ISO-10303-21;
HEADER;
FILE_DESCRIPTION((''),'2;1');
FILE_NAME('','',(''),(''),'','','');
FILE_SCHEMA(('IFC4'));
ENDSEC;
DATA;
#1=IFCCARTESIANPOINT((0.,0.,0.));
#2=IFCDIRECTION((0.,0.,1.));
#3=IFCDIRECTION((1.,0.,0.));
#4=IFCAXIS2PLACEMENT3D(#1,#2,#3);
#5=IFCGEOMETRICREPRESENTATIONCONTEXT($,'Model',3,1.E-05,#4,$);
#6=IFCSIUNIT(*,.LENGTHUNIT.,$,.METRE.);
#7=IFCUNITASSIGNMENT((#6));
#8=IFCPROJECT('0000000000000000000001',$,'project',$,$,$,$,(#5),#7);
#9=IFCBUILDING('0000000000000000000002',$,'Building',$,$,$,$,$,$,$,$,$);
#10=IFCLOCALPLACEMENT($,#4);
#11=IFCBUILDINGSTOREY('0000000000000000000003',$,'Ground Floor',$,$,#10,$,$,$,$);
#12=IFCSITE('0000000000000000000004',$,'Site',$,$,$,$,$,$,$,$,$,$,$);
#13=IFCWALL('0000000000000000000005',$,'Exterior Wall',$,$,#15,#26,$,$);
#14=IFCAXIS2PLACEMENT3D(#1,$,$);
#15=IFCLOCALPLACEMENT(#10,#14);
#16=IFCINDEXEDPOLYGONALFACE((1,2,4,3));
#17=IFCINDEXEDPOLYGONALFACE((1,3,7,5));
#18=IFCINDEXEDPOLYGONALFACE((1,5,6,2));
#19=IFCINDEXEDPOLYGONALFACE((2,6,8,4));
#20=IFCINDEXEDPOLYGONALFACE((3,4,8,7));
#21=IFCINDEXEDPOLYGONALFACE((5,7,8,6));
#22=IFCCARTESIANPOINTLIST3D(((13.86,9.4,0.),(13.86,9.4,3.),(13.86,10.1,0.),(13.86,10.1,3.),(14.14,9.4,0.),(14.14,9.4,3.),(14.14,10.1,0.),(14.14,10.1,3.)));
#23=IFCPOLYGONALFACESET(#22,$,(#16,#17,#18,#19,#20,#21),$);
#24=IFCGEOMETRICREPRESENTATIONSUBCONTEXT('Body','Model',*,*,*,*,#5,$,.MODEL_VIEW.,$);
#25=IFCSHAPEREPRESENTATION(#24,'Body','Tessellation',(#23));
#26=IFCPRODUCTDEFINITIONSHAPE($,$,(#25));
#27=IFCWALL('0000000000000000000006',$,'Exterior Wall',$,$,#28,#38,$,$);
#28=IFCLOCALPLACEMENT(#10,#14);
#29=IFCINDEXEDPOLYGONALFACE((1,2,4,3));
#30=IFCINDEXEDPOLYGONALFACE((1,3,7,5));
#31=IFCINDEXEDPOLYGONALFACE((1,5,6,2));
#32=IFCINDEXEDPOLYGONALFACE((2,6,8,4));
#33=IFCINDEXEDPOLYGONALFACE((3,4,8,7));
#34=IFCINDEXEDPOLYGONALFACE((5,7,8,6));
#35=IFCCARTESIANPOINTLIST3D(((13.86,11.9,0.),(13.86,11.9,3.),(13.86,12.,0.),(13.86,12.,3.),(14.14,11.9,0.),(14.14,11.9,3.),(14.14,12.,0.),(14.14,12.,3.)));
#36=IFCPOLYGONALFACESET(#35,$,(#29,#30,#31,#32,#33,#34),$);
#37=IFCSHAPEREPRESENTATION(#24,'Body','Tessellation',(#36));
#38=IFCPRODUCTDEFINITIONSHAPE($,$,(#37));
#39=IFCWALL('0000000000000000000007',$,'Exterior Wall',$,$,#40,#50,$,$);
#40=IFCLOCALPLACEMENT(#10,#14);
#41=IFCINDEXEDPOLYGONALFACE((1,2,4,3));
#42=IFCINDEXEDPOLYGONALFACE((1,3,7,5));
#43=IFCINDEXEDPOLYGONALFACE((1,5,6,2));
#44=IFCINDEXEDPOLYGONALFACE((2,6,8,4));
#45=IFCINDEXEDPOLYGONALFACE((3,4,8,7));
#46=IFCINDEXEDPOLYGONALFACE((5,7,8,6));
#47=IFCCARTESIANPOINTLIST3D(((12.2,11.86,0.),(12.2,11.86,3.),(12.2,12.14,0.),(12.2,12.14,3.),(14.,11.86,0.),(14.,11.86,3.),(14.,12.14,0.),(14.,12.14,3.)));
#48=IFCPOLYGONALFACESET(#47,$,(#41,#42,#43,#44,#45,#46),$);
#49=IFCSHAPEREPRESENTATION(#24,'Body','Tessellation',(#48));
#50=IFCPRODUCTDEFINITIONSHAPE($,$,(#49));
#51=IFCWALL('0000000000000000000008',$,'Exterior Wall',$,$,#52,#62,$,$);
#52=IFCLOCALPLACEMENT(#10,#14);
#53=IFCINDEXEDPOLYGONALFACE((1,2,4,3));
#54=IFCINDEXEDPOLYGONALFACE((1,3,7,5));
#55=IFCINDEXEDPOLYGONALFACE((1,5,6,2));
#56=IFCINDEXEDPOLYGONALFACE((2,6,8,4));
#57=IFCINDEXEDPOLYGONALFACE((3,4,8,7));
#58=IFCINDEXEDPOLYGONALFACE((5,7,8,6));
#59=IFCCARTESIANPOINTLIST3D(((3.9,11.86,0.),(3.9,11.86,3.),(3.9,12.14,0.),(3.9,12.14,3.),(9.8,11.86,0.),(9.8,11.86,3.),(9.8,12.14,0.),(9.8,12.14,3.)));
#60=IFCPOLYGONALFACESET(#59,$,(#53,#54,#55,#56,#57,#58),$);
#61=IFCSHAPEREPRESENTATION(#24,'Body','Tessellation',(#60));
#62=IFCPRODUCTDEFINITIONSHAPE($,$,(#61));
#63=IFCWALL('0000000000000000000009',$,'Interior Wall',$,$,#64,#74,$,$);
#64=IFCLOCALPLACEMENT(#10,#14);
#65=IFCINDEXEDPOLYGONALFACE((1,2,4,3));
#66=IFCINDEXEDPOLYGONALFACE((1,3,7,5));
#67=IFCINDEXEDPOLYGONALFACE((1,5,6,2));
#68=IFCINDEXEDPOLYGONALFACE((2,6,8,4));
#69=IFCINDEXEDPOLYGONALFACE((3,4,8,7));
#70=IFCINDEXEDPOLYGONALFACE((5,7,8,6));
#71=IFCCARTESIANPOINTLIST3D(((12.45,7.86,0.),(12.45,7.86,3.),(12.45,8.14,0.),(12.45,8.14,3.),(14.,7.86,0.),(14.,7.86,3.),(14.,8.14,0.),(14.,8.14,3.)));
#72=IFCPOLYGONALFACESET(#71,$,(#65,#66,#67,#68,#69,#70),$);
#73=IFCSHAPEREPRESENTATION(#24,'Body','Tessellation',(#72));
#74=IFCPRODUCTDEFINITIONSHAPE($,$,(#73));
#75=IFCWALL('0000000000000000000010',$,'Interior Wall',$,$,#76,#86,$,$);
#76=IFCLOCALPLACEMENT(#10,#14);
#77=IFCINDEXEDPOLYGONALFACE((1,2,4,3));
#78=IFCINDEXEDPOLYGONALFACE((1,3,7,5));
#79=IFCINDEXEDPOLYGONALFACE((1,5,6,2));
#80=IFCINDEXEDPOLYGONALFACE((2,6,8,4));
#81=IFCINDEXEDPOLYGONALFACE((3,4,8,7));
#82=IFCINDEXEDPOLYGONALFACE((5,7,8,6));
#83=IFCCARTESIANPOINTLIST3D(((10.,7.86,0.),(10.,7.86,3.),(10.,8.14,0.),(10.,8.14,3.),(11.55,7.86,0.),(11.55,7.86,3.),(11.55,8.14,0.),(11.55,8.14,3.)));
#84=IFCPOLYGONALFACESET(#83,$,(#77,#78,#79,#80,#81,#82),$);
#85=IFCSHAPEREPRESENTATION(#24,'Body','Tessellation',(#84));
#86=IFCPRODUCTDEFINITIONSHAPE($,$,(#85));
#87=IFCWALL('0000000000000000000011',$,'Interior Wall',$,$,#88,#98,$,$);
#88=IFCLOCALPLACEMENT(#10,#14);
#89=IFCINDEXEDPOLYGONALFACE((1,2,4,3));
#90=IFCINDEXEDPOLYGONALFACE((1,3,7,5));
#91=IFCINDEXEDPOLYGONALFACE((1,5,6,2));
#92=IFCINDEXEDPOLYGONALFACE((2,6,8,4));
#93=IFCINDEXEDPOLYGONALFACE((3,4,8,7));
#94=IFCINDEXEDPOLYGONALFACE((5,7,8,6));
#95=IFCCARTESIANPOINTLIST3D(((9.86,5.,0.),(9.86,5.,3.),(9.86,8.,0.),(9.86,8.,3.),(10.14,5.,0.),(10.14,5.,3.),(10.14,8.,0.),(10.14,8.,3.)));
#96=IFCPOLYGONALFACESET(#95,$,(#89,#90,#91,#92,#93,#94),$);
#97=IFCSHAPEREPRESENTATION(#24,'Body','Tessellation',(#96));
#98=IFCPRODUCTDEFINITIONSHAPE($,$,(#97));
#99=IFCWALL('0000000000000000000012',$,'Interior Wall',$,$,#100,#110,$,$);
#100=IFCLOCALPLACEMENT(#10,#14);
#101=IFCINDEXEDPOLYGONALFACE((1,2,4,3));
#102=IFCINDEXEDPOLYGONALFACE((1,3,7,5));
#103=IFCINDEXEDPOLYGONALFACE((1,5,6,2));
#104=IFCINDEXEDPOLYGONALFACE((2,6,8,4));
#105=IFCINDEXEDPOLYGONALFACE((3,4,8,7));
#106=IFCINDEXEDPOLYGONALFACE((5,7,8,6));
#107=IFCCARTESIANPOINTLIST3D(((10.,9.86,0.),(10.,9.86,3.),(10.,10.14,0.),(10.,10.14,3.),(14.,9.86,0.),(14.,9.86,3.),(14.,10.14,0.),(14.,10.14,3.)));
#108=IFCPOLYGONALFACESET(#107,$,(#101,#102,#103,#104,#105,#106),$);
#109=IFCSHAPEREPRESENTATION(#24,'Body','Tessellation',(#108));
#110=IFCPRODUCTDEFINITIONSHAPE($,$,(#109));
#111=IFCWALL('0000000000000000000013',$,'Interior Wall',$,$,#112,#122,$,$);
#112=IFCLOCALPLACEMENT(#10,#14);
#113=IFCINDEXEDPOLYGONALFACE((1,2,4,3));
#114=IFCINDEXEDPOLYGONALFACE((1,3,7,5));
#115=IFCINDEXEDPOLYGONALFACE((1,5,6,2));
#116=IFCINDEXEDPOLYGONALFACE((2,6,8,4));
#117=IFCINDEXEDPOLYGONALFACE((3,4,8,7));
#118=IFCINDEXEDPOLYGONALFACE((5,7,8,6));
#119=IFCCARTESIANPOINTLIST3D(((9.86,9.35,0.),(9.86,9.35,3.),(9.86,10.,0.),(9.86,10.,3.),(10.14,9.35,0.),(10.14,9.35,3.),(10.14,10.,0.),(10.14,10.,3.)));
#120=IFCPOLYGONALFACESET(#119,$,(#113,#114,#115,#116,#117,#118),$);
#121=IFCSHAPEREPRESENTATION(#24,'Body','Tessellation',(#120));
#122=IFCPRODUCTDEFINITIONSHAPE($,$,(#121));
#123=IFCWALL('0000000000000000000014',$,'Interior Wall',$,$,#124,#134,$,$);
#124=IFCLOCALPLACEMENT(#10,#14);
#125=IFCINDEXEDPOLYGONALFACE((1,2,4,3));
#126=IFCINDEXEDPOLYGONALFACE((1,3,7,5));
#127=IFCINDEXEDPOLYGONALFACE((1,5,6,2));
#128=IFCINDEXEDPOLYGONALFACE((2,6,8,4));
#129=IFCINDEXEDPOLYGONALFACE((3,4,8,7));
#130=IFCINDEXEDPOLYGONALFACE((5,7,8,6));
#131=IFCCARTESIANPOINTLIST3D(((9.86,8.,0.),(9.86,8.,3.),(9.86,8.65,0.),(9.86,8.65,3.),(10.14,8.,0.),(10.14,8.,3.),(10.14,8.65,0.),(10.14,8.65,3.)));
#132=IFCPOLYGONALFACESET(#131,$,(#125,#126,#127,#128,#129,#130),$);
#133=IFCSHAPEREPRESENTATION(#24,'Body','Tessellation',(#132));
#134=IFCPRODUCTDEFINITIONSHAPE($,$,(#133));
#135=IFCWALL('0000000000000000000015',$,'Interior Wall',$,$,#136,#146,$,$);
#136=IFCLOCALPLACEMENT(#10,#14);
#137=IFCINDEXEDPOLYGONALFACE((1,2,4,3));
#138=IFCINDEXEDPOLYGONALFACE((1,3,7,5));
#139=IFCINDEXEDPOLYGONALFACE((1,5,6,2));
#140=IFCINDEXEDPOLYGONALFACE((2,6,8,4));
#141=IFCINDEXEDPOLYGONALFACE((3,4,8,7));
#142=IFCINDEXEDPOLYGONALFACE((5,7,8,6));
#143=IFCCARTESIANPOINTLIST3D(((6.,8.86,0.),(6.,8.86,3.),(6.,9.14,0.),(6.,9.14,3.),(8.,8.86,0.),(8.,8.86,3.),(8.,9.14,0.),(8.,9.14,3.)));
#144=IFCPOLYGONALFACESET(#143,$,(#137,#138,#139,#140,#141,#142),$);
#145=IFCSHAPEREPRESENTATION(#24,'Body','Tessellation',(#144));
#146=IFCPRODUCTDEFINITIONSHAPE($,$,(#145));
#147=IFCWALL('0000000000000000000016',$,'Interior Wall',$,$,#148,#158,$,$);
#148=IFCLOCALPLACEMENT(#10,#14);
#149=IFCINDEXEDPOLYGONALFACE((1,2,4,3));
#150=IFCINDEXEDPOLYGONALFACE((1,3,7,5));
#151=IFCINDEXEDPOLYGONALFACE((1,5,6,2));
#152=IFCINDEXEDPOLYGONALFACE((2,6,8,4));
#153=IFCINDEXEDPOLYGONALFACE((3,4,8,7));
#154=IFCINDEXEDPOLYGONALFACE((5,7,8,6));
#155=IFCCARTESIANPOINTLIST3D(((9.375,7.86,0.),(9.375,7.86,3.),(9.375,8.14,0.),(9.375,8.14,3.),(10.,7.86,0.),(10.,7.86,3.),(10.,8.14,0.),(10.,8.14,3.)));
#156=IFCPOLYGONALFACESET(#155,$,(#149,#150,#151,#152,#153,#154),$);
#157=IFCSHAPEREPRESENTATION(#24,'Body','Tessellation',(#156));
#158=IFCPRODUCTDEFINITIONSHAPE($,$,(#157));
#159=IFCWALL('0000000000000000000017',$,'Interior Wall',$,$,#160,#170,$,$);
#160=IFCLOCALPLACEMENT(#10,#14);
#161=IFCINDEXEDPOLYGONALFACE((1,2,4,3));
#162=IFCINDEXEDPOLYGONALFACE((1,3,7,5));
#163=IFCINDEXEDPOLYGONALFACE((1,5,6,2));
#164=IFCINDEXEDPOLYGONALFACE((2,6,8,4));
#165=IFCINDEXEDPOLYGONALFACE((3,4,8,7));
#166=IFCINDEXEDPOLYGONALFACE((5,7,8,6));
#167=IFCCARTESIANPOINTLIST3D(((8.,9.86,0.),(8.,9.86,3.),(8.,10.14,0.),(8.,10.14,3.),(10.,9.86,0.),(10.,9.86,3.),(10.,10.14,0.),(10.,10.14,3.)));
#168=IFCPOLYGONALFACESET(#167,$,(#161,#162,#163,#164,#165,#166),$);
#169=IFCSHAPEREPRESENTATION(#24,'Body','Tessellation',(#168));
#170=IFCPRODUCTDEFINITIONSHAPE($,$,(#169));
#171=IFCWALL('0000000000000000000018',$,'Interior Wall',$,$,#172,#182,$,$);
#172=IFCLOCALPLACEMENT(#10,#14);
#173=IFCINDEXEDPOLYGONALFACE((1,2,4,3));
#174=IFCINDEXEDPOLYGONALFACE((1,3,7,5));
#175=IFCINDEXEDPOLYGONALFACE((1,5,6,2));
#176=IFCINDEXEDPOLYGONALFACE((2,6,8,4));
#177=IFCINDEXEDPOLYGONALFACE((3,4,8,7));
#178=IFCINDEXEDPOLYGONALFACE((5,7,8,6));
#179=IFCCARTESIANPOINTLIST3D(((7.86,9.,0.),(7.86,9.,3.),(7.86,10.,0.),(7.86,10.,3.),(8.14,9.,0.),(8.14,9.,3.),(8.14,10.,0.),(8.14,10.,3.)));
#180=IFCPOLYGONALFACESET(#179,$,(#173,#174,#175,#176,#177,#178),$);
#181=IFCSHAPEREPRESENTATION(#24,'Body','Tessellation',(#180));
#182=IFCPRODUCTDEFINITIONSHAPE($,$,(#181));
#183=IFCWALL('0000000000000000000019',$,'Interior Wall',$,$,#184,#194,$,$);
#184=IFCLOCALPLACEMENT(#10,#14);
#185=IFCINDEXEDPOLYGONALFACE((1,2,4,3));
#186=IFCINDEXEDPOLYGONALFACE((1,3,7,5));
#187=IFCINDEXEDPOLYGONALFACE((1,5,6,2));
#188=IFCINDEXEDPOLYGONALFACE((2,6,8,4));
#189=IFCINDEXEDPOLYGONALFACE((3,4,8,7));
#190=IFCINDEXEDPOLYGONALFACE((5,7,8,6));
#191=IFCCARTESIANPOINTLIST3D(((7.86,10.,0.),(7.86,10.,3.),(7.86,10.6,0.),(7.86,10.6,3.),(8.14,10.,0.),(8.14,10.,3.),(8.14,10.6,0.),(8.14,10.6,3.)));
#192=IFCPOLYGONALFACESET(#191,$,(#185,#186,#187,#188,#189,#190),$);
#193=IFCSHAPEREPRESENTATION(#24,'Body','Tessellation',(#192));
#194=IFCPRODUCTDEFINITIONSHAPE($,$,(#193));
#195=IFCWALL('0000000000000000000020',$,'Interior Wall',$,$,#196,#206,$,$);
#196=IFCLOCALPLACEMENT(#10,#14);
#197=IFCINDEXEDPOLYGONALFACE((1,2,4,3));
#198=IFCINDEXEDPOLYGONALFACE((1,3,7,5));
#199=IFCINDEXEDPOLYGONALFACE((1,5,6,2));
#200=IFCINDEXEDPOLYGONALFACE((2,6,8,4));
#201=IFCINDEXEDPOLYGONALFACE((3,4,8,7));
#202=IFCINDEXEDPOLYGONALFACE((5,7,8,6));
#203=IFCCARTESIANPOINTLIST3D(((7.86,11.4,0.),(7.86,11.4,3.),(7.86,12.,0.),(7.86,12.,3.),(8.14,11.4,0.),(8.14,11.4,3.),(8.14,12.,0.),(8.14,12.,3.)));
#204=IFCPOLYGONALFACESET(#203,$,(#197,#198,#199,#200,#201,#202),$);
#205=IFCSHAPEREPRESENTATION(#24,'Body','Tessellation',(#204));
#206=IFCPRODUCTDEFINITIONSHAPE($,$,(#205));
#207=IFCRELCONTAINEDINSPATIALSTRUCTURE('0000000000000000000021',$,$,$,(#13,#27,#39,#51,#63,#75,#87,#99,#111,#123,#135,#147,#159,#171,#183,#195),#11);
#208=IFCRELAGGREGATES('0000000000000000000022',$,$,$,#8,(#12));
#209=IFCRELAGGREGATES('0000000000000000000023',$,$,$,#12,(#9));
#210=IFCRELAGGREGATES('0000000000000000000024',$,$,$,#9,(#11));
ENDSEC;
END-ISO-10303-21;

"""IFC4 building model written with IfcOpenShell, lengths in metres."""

from ifc_helpers import new_model, si_unit, frame, origin_with_axes, place, context, subcontext, project, spatial, indexed_curve, outline, extrude, element, save


model = new_model("IFC4")

# Units and contexts
model_context = context("Model", 3, precision=1e-05, world=origin_with_axes())
body_context = subcontext(model_context, "Body", "Model", "MODEL_VIEW")
ifc_project = project(units=[si_unit("LENGTHUNIT", "METRE")], contexts=[model_context])

# Site, building, storey
site = spatial("IfcSite", under=ifc_project, Name="Site")
building = spatial("IfcBuilding", under=site, Name="Building")
storey_placement = place(None, origin_with_axes())
storey = spatial("IfcBuildingStorey", under=building, at=storey_placement, Name="Ground Floor")

# Walls
wall_1_placement = place(storey_placement, frame((14.0, 9.4, 0.0), z_axis=(0.0, 0.0, 1.0), x_axis=(0.0, 1.0, 0.0)))
element("IfcWall", 1, at=wall_1_placement, inside=storey, Name="Exterior Wall", context=body_context, shape_type="SweptSolid", body=[
    extrude(outline(indexed_curve([(0.0, 0.0), (0.0, 0.28), (0.7, 0.28), (0.7, 0.0), (0.0, 0.0)], self_intersect=False)), frame((0.0, -0.14, 0.0), z_axis=(0.0, 0.0, 1.0), x_axis=(1.0, 0.0, 0.0)), (0.0, 0.0, 1.0), 3.0),
])
wall_2_placement = place(storey_placement, frame((14.0, 11.9, 0.0), z_axis=(0.0, 0.0, 1.0), x_axis=(0.0, 1.0, 0.0)))
element("IfcWall", 2, at=wall_2_placement, inside=storey, Name="Exterior Wall", context=body_context, shape_type="SweptSolid", body=[
    extrude(outline(indexed_curve([(0.0, 0.0), (0.0, 0.28), (0.1, 0.28), (0.1, 0.0), (0.0, 0.0)], self_intersect=False)), frame((0.0, -0.14, 0.0), z_axis=(0.0, 0.0, 1.0), x_axis=(1.0, 0.0, 0.0)), (0.0, 0.0, 1.0), 3.0),
])
wall_3_placement = place(storey_placement, frame((14.0, 12.0, 0.0), z_axis=(0.0, 0.0, 1.0), x_axis=(-1.0, 0.0, 0.0)))
element("IfcWall", 3, at=wall_3_placement, inside=storey, Name="Exterior Wall", context=body_context, shape_type="SweptSolid", body=[
    extrude(outline(indexed_curve([(0.0, 0.0), (0.0, 0.28), (1.8, 0.28), (1.8, 0.0), (0.0, 0.0)], self_intersect=False)), frame((0.0, -0.14, 0.0), z_axis=(0.0, 0.0, 1.0), x_axis=(1.0, 0.0, 0.0)), (0.0, 0.0, 1.0), 3.0),
])
wall_4_placement = place(storey_placement, frame((9.8, 12.0, 0.0), z_axis=(0.0, 0.0, 1.0), x_axis=(-1.0, 0.0, 0.0)))
element("IfcWall", 4, at=wall_4_placement, inside=storey, Name="Exterior Wall", context=body_context, shape_type="SweptSolid", body=[
    extrude(outline(indexed_curve([(0.0, 0.0), (0.0, 0.28), (5.9, 0.28), (5.9, 0.0), (0.0, 0.0)], self_intersect=False)), frame((0.0, -0.14, 0.0), z_axis=(0.0, 0.0, 1.0), x_axis=(1.0, 0.0, 0.0)), (0.0, 0.0, 1.0), 3.0),
])
for number, where, z_axis, x_axis, name in (
    (5, (14.0, 8.0, 0.0), (0.0, 0.0, 1.0), (-1.0, 0.0, 0.0), "Interior Wall"),
    (6, (11.55, 8.0, 0.0), (0.0, 0.0, 1.0), (-1.0, 0.0, 0.0), "Interior Wall"),
):
    element("IfcWall", number, at=place(storey_placement, frame(where, z_axis=z_axis, x_axis=x_axis)), inside=storey, Name=name, context=body_context, shape_type="SweptSolid", body=[
        extrude(outline(indexed_curve([(0.0, 0.0), (0.0, 0.28), (1.55, 0.28), (1.55, 0.0), (0.0, 0.0)], self_intersect=False)), frame((0.0, -0.14, 0.0), z_axis=(0.0, 0.0, 1.0), x_axis=(1.0, 0.0, 0.0)), (0.0, 0.0, 1.0), 3.0),
    ])
wall_5_placement = place(storey_placement, frame((10.0, 8.0, 0.0), z_axis=(0.0, 0.0, 1.0), x_axis=(0.0, -1.0, 0.0)))
element("IfcWall", 7, at=wall_5_placement, inside=storey, Name="Interior Wall", context=body_context, shape_type="SweptSolid", body=[
    extrude(outline(indexed_curve([(0.0, 0.0), (0.0, 0.28), (3.0, 0.28), (3.0, 0.0), (0.0, 0.0)], self_intersect=False)), frame((0.0, -0.14, 0.0), z_axis=(0.0, 0.0, 1.0), x_axis=(1.0, 0.0, 0.0)), (0.0, 0.0, 1.0), 3.0),
])
wall_6_placement = place(storey_placement, frame((14.0, 10.0, 0.0), z_axis=(0.0, 0.0, 1.0), x_axis=(-1.0, 0.0, 0.0)))
element("IfcWall", 8, at=wall_6_placement, inside=storey, Name="Interior Wall", context=body_context, shape_type="SweptSolid", body=[
    extrude(outline(indexed_curve([(0.0, 0.0), (0.0, 0.28), (4.0, 0.28), (4.0, 0.0), (0.0, 0.0)], self_intersect=False)), frame((0.0, -0.14, 0.0), z_axis=(0.0, 0.0, 1.0), x_axis=(1.0, 0.0, 0.0)), (0.0, 0.0, 1.0), 3.0),
])
for number, where, z_axis, x_axis, name in (
    (9, (10.0, 10.0, 0.0), (0.0, 0.0, 1.0), (0.0, -1.0, 0.0), "Interior Wall"),
    (10, (10.0, 8.65, 0.0), (0.0, 0.0, 1.0), (0.0, -1.0, 0.0), "Interior Wall"),
):
    element("IfcWall", number, at=place(storey_placement, frame(where, z_axis=z_axis, x_axis=x_axis)), inside=storey, Name=name, context=body_context, shape_type="SweptSolid", body=[
        extrude(outline(indexed_curve([(0.0, 0.0), (0.0, 0.28), (0.65, 0.28), (0.65, 0.0), (0.0, 0.0)], self_intersect=False)), frame((0.0, -0.14, 0.0), z_axis=(0.0, 0.0, 1.0), x_axis=(1.0, 0.0, 0.0)), (0.0, 0.0, 1.0), 3.0),
    ])
wall_7_placement = place(storey_placement, frame((8.0, 9.0, 0.0), z_axis=(0.0, 0.0, 1.0), x_axis=(-1.0, 0.0, 0.0)))
element("IfcWall", 11, at=wall_7_placement, inside=storey, Name="Interior Wall", context=body_context, shape_type="SweptSolid", body=[
    extrude(outline(indexed_curve([(0.0, 0.0), (0.0, 0.28), (2.0, 0.28), (2.0, 0.0), (0.0, 0.0)], self_intersect=False)), frame((0.0, -0.14, 0.0), z_axis=(0.0, 0.0, 1.0), x_axis=(1.0, 0.0, 0.0)), (0.0, 0.0, 1.0), 3.0),
])
wall_8_placement = place(storey_placement, frame((10.0, 8.0, 0.0), z_axis=(0.0, 0.0, 1.0), x_axis=(-1.0, 0.0, 0.0)))
element("IfcWall", 12, at=wall_8_placement, inside=storey, Name="Interior Wall", context=body_context, shape_type="SweptSolid", body=[
    extrude(outline(indexed_curve([(0.0, 0.0), (0.0, 0.28), (0.625, 0.28), (0.625, 0.0), (0.0, 0.0)], self_intersect=False)), frame((0.0, -0.14, 0.0), z_axis=(0.0, 0.0, 1.0), x_axis=(1.0, 0.0, 0.0)), (0.0, 0.0, 1.0), 3.0),
])
wall_9_placement = place(storey_placement, frame((10.0, 10.0, 0.0), z_axis=(0.0, 0.0, 1.0), x_axis=(-1.0, 0.0, 0.0)))
element("IfcWall", 13, at=wall_9_placement, inside=storey, Name="Interior Wall", context=body_context, shape_type="SweptSolid", body=[
    extrude(outline(indexed_curve([(0.0, 0.0), (0.0, 0.28), (2.0, 0.28), (2.0, 0.0), (0.0, 0.0)], self_intersect=False)), frame((0.0, -0.14, 0.0), z_axis=(0.0, 0.0, 1.0), x_axis=(1.0, 0.0, 0.0)), (0.0, 0.0, 1.0), 3.0),
])
wall_10_placement = place(storey_placement, frame((8.0, 10.0, 0.0), z_axis=(0.0, 0.0, 1.0), x_axis=(0.0, -1.0, 0.0)))
element("IfcWall", 14, at=wall_10_placement, inside=storey, Name="Interior Wall", context=body_context, shape_type="SweptSolid", body=[
    extrude(outline(indexed_curve([(0.0, 0.0), (0.0, 0.28), (1.0, 0.28), (1.0, 0.0), (0.0, 0.0)], self_intersect=False)), frame((0.0, -0.14, 0.0), z_axis=(0.0, 0.0, 1.0), x_axis=(1.0, 0.0, 0.0)), (0.0, 0.0, 1.0), 3.0),
])
for number, where, z_axis, x_axis, name in (
    (15, (8.0, 10.0, 0.0), (0.0, 0.0, 1.0), (0.0, 1.0, 0.0), "Interior Wall"),
    (16, (8.0, 11.4, 0.0), (0.0, 0.0, 1.0), (0.0, 1.0, 0.0), "Interior Wall"),
):
    element("IfcWall", number, at=place(storey_placement, frame(where, z_axis=z_axis, x_axis=x_axis)), inside=storey, Name=name, context=body_context, shape_type="SweptSolid", body=[
        extrude(outline(indexed_curve([(0.0, 0.0), (0.0, 0.28), (0.6, 0.28), (0.6, 0.0), (0.0, 0.0)], self_intersect=False)), frame((0.0, -0.14, 0.0), z_axis=(0.0, 0.0, 1.0), x_axis=(1.0, 0.0, 0.0)), (0.0, 0.0, 1.0), 3.0),
    ])

save(model, "model.ifc")
